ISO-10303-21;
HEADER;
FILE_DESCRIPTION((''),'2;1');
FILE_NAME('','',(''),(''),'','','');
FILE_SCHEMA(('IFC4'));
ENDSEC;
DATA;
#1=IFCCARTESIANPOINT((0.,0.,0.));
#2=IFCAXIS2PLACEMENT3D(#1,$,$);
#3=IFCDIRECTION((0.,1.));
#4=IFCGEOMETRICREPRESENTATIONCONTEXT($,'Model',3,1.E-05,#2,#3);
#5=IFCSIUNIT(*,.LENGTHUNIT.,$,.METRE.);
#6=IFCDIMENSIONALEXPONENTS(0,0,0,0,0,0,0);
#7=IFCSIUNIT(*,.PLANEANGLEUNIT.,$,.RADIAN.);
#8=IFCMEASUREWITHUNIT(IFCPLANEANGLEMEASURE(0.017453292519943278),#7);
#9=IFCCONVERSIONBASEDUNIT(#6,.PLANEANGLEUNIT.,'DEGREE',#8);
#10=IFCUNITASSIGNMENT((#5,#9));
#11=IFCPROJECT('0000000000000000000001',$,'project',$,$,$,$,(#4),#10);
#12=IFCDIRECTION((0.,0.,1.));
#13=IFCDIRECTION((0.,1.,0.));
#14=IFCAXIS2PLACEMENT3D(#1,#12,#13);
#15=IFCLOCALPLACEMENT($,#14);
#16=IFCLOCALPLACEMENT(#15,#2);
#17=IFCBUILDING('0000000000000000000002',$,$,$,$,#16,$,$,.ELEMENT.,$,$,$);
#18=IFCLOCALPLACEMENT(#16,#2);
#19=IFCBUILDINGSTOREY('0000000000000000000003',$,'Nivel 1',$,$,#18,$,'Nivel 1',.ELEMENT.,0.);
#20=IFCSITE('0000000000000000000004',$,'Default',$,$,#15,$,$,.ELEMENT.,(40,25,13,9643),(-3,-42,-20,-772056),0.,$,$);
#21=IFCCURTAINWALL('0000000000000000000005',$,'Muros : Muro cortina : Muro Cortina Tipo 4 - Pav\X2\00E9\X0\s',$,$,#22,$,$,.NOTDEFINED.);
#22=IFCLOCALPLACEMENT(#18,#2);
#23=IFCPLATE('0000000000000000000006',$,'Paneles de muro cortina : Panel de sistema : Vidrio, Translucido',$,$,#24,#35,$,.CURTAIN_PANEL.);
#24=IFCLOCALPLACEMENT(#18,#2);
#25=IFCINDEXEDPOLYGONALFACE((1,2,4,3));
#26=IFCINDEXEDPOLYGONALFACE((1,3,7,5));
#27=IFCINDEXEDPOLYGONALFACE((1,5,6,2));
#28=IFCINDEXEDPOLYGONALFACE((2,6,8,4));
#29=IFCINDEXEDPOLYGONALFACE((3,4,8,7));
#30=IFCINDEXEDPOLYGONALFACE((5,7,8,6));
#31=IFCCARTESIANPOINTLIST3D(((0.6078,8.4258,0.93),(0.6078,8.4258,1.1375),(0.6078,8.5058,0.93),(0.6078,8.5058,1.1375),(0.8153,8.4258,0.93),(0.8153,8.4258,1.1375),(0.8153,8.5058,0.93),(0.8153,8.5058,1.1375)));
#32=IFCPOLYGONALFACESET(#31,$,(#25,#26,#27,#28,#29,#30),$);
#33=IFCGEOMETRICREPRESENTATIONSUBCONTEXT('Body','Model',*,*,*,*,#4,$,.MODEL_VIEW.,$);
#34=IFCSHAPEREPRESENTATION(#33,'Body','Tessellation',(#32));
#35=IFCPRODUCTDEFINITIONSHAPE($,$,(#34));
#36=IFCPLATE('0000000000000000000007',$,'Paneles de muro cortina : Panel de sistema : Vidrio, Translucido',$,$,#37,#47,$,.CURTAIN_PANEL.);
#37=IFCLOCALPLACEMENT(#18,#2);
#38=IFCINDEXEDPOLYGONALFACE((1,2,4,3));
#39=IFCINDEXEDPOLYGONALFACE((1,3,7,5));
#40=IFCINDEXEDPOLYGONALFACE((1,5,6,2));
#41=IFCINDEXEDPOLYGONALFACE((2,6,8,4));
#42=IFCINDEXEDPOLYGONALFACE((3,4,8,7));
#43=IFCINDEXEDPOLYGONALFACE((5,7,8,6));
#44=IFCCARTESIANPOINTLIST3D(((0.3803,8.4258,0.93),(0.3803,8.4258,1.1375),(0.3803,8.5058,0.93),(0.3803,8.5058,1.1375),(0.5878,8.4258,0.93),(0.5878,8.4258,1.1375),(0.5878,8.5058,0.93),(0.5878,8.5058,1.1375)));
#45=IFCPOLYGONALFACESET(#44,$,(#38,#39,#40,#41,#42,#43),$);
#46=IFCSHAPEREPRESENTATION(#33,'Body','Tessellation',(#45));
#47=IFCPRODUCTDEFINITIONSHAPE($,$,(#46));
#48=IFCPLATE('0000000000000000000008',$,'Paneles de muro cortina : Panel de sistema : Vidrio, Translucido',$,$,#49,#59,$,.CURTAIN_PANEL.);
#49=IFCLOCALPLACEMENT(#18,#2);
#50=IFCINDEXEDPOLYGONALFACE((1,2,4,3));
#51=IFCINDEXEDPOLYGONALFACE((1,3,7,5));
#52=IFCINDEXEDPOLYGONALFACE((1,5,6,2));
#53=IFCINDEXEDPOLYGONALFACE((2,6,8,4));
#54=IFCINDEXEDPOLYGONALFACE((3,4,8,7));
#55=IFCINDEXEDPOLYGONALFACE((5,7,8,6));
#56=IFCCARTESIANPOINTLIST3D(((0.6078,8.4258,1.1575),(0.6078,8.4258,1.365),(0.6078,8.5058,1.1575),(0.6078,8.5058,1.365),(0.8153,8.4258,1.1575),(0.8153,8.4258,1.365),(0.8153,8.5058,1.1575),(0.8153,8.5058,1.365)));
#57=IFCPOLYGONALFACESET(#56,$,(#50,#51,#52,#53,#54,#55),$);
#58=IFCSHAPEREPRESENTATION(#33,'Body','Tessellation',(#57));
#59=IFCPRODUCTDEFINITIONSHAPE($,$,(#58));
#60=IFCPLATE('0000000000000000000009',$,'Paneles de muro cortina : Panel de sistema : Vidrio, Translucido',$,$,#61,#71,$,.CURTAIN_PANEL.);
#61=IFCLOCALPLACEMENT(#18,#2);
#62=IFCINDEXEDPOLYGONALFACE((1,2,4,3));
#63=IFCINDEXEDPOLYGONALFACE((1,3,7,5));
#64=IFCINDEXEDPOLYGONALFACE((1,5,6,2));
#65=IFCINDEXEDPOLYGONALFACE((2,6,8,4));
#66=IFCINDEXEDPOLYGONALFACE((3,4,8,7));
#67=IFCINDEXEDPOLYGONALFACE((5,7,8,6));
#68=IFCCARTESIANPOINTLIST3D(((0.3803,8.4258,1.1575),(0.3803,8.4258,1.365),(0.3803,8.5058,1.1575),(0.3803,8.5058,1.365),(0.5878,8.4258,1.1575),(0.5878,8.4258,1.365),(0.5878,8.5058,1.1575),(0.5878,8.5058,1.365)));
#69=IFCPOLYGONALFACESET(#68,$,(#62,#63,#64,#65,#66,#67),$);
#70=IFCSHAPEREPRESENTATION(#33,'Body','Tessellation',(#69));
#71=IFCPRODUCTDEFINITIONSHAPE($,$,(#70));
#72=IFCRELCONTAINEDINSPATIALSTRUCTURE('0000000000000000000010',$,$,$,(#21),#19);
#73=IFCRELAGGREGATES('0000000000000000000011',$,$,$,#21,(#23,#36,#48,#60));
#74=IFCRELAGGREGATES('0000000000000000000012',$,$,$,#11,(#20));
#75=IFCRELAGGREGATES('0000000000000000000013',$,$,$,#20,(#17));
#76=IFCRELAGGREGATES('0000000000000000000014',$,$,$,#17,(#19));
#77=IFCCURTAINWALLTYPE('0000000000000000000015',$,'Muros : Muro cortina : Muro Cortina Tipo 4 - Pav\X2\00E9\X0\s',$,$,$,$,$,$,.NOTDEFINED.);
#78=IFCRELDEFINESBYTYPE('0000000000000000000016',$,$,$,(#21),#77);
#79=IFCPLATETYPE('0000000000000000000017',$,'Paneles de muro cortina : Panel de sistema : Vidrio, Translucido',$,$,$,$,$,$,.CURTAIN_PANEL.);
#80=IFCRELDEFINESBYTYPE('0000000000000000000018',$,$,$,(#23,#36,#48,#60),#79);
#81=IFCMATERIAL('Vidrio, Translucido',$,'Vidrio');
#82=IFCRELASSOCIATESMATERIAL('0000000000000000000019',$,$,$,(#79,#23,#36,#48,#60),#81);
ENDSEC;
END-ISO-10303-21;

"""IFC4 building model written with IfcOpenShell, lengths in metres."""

from ifc_helpers import new_model, entity, si_unit, converted_unit, direction, frame, origin, place, context, subcontext, project, spatial, indexed_curve, outline, extrude, source, transform, mapped, material, type_object, type_shapes, element, aggregate, save


model = new_model("IFC4")

# Units and contexts
model_context = context("Model", 3, precision=1e-05, world=origin(), true_north=direction((0.0, 1.0)))
body_context = subcontext(model_context, "Body", "Model", "MODEL_VIEW")
ifc_project = project(units=[si_unit("LENGTHUNIT", "METRE"), converted_unit("PLANEANGLEUNIT", "DEGREE", entity("IfcPlaneAngleMeasure", 0.017453292519943278), si_unit("PLANEANGLEUNIT", "RADIAN"), dimensions=[0, 0, 0, 0, 0, 0, 0])], contexts=[model_context])

# Site, building, storey
site_placement = place(None, frame((0.0, 0.0, 0.0), z_axis=(0.0, 0.0, 1.0), x_axis=(0.0, 1.0, 0.0)))
site = spatial("IfcSite", under=ifc_project, at=site_placement, Name="Default", CompositionType="ELEMENT", RefLatitude=(40, 25, 13, 9643), RefLongitude=(-3, -42, -20, -772056), RefElevation=0.0)
building_placement = place(site_placement, origin())
building = spatial("IfcBuilding", under=site, at=building_placement, CompositionType="ELEMENT")
storey_placement = place(building_placement, origin())
storey = spatial("IfcBuildingStorey", under=building, at=storey_placement, Name="Nivel 1", LongName="Nivel 1", CompositionType="ELEMENT", Elevation=0.0)

# Curtain wall, plates
curtain_wall_type = type_object("IfcCurtainWallType", Name="Muros : Muro cortina : Muro Cortina Tipo 4 - Pavés", PredefinedType="NOTDEFINED")
curtain_wall_placement = place(storey_placement, origin())
curtain_wall = element("IfcCurtainWall", 1, at=curtain_wall_placement, inside=storey, type_object=curtain_wall_type, Name="Muros : Muro cortina : Muro Cortina Tipo 4 - Pavés", PredefinedType="NOTDEFINED")
ifc_material_1 = material(Name="Vidrio, Translucido", Category="Vidrio")
plate_type = type_object("IfcPlateType", Name="Paneles de muro cortina : Panel de sistema : Vidrio, Translucido", PredefinedType="CURTAIN_PANEL", material=ifc_material_1)
shared_shape_1 = source(origin(), body_context, "Body", "SweptSolid", [
    extrude(outline(indexed_curve([(-0.04, -0.1038), (0.04, -0.1038), (0.04, 0.1038), (-0.04, 0.1038), (-0.04, -0.1038)], self_intersect=False)), frame((0.0, 0.0, 0.0), z_axis=(0.0, 0.0, 1.0), x_axis=(0.0, 1.0, 0.0)), (0.0, 0.0, 1.0), 0.2075),
])
type_shapes(plate_type, [shared_shape_1])
plate_1_placement = place(curtain_wall_placement, frame((0.7115, 8.4658, 0.93), z_axis=(0.0, 0.0, 1.0), x_axis=(-1.0, 0.0, 0.0)))
plate_1 = element("IfcPlate", 2, at=plate_1_placement, type_object=plate_type, material=ifc_material_1, Name="Paneles de muro cortina : Panel de sistema : Vidrio, Translucido", PredefinedType="CURTAIN_PANEL", context=body_context, shape_type="MappedRepresentation", body=[
    mapped(shared_shape_1, transform((0.0, 0.0, 0.0), scale=1.0)),
])
plate_2_placement = place(curtain_wall_placement, frame((0.484, 8.4658, 0.93), z_axis=(0.0, 0.0, 1.0), x_axis=(-1.0, 0.0, 0.0)))
plate_2 = element("IfcPlate", 3, at=plate_2_placement, type_object=plate_type, material=ifc_material_1, Name="Paneles de muro cortina : Panel de sistema : Vidrio, Translucido", PredefinedType="CURTAIN_PANEL", context=body_context, shape_type="MappedRepresentation", body=[
    mapped(shared_shape_1, transform((0.0, 0.0, 0.0), scale=1.0)),
])
plate_3_placement = place(curtain_wall_placement, frame((0.7115, 8.4658, 1.1575), z_axis=(0.0, 0.0, 1.0), x_axis=(-1.0, 0.0, 0.0)))
plate_3 = element("IfcPlate", 4, at=plate_3_placement, type_object=plate_type, material=ifc_material_1, Name="Paneles de muro cortina : Panel de sistema : Vidrio, Translucido", PredefinedType="CURTAIN_PANEL", context=body_context, shape_type="MappedRepresentation", body=[
    mapped(shared_shape_1, transform((0.0, 0.0, 0.0), scale=1.0)),
])
plate_4_placement = place(curtain_wall_placement, frame((0.484, 8.4658, 1.1575), z_axis=(0.0, 0.0, 1.0), x_axis=(-1.0, 0.0, 0.0)))
plate_4 = element("IfcPlate", 5, at=plate_4_placement, type_object=plate_type, material=ifc_material_1, Name="Paneles de muro cortina : Panel de sistema : Vidrio, Translucido", PredefinedType="CURTAIN_PANEL", context=body_context, shape_type="MappedRepresentation", body=[
    mapped(shared_shape_1, transform((0.0, 0.0, 0.0), scale=1.0)),
])
aggregate(curtain_wall, [plate_1, plate_2, plate_3, plate_4])

save(model, "model.ifc")
